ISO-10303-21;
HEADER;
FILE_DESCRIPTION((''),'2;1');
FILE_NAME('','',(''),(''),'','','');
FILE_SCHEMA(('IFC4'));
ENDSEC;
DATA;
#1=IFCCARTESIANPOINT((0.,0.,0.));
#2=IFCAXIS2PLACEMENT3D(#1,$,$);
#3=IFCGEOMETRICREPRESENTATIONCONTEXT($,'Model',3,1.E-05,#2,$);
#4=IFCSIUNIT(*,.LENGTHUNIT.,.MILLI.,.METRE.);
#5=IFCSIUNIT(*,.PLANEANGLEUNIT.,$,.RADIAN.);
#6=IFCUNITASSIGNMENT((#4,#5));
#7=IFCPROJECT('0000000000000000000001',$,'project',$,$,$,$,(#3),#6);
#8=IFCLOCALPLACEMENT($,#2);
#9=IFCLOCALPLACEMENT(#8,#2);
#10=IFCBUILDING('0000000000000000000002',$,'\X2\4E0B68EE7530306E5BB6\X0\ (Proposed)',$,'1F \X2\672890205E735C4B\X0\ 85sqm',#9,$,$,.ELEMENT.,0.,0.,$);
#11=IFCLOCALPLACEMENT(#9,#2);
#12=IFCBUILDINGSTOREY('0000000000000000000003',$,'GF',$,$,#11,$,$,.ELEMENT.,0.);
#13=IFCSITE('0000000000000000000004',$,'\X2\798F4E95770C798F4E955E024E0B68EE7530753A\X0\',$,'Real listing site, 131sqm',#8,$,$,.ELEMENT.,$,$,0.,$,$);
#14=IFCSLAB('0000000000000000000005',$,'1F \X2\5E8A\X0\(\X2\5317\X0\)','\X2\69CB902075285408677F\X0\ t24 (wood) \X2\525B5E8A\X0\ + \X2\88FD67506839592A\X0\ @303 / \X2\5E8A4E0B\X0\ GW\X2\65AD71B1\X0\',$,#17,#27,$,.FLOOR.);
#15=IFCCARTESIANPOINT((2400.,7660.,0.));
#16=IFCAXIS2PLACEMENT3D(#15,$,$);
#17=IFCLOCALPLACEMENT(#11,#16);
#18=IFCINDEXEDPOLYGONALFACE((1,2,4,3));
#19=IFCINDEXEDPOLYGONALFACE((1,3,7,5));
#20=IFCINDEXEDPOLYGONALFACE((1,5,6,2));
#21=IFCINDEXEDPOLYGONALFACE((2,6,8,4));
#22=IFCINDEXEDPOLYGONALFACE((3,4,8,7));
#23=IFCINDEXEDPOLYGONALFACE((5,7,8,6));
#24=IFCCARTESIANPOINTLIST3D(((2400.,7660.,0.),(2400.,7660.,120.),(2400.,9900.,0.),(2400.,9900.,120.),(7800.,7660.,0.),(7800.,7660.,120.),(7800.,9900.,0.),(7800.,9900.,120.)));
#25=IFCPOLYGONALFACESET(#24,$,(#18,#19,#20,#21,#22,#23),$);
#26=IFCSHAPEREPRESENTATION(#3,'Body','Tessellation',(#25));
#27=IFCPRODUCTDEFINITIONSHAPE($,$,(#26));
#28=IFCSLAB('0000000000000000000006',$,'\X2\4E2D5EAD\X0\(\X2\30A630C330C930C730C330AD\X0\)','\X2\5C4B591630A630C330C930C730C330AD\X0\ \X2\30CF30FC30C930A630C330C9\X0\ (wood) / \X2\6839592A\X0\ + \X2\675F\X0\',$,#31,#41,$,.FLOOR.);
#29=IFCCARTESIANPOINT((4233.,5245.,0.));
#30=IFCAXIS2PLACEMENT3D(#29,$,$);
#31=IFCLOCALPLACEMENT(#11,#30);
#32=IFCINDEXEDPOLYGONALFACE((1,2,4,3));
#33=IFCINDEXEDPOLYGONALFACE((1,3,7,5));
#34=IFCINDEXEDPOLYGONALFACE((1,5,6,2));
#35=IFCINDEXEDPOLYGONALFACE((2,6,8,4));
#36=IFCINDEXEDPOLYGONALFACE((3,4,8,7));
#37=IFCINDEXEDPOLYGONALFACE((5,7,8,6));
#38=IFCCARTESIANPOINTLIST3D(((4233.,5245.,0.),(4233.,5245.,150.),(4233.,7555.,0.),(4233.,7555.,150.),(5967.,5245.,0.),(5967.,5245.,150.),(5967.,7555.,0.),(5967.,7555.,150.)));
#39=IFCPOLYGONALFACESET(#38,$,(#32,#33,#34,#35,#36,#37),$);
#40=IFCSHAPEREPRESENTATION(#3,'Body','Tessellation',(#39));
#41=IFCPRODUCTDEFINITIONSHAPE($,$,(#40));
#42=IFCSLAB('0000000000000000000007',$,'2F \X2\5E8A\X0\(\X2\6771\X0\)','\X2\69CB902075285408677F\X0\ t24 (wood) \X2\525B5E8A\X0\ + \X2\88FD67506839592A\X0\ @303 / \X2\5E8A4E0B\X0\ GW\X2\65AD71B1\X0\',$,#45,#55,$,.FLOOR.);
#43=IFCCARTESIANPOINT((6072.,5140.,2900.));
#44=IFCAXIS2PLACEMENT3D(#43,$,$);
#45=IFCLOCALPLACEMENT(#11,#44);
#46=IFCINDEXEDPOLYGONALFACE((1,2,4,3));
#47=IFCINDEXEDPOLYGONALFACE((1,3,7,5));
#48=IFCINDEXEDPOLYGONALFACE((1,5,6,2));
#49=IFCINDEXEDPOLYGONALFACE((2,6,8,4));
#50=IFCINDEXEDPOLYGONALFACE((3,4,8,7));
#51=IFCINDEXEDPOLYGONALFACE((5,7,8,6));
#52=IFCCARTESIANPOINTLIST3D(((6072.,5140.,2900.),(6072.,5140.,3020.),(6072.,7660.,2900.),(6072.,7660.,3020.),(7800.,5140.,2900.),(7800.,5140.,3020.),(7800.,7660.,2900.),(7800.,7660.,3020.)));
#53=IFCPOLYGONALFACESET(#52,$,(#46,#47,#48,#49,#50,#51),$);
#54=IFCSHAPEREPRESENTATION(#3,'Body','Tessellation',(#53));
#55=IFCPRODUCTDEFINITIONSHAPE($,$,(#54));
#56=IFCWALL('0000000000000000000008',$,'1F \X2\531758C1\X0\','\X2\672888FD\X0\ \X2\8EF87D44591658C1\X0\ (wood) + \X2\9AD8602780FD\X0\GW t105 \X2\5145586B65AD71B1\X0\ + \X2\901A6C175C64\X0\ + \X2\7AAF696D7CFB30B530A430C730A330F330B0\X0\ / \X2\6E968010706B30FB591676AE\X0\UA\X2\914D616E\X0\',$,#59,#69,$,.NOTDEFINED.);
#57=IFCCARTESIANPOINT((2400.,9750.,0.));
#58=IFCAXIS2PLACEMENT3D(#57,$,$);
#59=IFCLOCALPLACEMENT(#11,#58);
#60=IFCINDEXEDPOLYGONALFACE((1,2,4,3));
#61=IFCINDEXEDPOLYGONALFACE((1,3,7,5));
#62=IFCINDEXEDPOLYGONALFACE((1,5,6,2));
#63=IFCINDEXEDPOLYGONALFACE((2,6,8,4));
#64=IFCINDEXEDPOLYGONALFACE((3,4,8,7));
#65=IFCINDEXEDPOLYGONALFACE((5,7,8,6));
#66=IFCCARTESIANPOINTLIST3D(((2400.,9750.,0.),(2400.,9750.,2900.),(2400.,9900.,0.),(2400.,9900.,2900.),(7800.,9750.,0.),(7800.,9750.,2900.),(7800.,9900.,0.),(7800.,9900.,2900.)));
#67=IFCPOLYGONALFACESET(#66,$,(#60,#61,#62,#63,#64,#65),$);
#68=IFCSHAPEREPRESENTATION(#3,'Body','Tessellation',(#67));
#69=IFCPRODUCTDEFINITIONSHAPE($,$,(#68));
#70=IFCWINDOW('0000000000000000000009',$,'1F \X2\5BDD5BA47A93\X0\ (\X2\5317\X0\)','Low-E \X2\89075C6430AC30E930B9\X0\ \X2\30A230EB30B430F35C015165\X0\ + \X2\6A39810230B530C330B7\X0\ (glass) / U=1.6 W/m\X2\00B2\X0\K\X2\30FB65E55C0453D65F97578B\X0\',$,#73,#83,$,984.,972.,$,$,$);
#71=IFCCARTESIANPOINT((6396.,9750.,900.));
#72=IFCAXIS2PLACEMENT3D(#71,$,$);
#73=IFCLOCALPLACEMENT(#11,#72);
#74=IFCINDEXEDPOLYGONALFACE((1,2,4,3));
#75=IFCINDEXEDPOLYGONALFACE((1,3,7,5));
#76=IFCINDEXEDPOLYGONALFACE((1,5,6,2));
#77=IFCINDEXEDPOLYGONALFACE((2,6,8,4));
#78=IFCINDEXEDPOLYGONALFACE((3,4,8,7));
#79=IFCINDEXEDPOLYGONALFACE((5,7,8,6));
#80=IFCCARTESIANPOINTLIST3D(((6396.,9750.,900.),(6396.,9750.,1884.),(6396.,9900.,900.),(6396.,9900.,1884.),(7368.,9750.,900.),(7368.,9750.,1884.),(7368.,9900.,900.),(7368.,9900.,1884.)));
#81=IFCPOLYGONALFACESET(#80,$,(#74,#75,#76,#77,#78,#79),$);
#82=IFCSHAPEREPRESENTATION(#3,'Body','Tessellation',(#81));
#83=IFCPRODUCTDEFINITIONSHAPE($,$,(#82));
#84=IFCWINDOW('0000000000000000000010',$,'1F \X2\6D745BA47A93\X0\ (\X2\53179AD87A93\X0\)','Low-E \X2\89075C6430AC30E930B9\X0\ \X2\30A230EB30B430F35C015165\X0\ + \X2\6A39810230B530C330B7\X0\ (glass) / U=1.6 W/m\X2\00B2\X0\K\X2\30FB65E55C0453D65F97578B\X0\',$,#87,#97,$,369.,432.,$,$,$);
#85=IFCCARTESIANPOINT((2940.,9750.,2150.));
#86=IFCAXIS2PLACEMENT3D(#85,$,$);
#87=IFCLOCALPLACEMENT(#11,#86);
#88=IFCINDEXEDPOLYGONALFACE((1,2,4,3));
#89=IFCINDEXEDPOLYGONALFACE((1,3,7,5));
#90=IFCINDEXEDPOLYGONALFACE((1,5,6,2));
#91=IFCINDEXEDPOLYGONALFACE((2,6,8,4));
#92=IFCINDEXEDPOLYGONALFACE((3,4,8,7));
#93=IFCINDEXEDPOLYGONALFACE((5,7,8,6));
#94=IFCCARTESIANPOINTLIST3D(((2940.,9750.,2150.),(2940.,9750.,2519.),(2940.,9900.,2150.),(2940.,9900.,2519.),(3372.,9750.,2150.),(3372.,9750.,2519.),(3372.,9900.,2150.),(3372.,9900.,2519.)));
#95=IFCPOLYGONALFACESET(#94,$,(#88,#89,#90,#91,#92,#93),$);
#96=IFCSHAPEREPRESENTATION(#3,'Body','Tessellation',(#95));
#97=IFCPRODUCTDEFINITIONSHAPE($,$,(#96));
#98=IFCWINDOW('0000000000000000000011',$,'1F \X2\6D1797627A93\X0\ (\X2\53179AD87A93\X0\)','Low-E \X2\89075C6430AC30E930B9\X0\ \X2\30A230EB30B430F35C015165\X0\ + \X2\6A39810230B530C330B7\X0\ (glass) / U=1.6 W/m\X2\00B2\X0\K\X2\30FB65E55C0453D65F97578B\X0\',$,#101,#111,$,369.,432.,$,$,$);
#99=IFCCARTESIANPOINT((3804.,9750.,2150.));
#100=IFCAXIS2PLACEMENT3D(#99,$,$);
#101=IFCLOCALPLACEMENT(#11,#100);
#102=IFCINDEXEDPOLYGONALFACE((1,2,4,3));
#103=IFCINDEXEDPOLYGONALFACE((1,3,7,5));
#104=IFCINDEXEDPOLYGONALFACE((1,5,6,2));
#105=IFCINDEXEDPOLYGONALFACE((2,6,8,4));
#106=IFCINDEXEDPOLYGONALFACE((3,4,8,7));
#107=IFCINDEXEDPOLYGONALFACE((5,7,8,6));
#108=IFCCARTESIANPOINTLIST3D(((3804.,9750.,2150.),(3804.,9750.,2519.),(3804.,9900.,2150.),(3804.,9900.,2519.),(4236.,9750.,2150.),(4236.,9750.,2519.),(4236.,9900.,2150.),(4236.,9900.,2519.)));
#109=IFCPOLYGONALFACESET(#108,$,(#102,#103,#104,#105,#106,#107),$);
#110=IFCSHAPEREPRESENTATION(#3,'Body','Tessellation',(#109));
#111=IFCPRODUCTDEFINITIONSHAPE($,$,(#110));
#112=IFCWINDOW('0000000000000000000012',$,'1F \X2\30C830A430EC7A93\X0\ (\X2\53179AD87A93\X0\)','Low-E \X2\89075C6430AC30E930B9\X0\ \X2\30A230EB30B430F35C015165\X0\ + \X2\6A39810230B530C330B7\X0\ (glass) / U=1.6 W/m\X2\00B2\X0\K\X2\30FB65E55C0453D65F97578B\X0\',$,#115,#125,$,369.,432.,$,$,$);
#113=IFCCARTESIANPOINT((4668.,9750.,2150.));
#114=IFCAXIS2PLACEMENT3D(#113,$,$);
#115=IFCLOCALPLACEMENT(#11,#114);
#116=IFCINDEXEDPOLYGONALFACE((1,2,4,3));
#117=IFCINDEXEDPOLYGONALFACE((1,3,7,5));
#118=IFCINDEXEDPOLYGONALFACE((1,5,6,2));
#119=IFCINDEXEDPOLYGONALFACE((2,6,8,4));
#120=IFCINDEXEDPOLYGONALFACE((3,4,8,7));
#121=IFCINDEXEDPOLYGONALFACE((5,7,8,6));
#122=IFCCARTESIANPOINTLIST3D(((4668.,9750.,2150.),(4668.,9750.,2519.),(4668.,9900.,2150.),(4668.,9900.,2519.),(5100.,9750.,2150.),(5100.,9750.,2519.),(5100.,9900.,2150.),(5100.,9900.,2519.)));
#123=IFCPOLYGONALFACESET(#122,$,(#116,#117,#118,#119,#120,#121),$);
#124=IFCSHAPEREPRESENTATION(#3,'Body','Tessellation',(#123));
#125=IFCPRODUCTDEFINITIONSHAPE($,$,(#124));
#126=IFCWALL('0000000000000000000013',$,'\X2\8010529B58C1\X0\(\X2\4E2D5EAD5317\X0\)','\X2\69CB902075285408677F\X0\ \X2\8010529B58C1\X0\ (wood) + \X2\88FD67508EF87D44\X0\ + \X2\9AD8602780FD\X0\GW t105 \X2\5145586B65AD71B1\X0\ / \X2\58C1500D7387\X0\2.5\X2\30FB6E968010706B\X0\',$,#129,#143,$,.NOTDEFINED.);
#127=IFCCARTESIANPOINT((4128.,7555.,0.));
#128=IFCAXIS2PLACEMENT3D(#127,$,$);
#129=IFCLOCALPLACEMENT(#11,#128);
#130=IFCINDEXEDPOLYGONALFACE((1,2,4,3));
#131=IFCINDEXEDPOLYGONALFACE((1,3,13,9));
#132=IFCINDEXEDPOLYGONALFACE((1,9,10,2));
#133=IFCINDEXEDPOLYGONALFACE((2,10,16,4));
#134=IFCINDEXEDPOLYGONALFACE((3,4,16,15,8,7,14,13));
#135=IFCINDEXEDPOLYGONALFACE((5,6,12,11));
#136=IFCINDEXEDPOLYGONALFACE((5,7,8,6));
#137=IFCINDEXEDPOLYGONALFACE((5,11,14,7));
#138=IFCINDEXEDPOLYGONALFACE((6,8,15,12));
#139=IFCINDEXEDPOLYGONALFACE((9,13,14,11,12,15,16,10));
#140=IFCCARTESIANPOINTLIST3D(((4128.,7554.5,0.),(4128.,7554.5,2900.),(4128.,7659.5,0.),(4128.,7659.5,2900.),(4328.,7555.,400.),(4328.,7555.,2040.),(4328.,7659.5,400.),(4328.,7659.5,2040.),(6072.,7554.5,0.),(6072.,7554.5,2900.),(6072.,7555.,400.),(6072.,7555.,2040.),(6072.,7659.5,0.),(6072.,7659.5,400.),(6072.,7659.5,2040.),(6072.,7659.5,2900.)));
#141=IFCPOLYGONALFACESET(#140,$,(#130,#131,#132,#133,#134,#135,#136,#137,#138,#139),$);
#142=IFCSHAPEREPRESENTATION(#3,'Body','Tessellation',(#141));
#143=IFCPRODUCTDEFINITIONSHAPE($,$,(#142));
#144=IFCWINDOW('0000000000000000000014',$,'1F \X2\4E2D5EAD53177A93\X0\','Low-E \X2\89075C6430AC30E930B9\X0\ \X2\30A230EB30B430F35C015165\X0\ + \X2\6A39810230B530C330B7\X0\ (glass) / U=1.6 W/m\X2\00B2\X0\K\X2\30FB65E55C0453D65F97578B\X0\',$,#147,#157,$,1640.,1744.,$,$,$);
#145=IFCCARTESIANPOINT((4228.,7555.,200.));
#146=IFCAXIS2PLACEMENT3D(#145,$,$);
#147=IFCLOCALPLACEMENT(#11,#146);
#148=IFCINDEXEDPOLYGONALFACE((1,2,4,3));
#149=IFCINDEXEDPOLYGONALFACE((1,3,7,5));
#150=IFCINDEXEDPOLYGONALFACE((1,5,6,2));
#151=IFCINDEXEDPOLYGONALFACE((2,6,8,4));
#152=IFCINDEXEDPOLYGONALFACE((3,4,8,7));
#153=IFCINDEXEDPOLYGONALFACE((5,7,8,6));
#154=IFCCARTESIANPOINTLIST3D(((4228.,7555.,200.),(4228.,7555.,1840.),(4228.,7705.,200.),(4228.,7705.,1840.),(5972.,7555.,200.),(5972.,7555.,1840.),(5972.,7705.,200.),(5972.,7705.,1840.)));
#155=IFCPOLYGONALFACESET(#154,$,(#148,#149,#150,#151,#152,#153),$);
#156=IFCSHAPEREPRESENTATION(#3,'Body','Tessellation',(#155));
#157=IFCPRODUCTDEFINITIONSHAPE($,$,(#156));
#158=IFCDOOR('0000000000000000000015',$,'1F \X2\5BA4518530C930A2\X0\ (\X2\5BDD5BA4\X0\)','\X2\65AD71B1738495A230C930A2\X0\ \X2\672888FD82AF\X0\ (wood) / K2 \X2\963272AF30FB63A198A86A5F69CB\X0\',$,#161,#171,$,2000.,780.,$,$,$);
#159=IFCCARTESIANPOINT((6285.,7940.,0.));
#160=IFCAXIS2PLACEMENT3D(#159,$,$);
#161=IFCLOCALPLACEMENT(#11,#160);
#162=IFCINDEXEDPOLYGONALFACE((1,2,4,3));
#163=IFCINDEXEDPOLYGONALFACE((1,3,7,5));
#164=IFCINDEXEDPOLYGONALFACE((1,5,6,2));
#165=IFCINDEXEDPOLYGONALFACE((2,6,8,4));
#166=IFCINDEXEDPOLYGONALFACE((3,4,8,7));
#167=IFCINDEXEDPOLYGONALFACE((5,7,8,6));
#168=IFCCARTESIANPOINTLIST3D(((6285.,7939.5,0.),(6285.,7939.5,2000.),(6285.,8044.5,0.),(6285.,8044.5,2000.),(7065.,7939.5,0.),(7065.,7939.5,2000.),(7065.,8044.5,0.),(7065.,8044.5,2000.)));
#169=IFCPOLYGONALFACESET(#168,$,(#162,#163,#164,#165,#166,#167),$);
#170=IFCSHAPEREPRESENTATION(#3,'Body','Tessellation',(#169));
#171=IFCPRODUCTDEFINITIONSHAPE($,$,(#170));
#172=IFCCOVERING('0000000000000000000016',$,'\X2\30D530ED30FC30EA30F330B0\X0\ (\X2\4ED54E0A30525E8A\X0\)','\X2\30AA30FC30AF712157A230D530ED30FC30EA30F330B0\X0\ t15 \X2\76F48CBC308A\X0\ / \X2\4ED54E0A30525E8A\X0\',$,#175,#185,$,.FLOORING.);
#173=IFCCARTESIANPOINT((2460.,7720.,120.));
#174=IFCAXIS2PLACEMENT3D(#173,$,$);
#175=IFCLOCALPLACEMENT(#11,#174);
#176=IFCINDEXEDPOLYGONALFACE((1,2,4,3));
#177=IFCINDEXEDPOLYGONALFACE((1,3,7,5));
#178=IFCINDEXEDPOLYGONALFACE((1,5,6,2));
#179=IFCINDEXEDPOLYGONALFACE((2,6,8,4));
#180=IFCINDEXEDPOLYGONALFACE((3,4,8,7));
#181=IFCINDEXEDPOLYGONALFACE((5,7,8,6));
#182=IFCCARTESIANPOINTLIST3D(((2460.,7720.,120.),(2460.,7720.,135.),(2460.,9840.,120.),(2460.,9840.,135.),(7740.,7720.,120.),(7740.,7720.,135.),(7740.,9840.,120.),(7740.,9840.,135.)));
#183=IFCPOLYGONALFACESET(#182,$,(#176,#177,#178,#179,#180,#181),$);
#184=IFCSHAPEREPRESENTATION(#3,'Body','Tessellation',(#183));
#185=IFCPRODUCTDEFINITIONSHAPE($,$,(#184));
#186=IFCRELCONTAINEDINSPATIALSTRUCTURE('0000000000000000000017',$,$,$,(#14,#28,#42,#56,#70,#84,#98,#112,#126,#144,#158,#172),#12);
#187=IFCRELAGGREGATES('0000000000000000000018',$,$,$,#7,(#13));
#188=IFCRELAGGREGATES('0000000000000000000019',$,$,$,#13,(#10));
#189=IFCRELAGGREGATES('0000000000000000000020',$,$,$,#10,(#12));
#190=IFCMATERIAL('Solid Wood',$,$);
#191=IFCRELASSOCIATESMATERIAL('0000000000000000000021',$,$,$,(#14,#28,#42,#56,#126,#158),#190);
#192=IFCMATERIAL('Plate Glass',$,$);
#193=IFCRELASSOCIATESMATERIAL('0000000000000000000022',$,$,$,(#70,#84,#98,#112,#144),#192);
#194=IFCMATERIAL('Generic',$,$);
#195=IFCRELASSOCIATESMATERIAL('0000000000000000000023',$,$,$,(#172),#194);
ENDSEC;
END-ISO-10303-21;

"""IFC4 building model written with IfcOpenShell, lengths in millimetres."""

from ifc_helpers import new_model, si_unit, frame, frame_2d, origin, place, context, project, spatial, rectangle, extrude, material, element, fill, save


model = new_model("IFC4")

# Units and contexts
model_context = context("Model", 3, precision=1e-05, world=origin())
ifc_project = project(units=[si_unit("LENGTHUNIT", "METRE", prefix="MILLI"), si_unit("PLANEANGLEUNIT", "RADIAN")], contexts=[model_context])

# Site, building, storey
site_placement = place(None, origin())
site = spatial("IfcSite", under=ifc_project, at=site_placement, Name="福井県福井市下森田町", ObjectType="Real listing site, 131sqm", CompositionType="ELEMENT", RefElevation=0.0)
building_placement = place(site_placement, origin())
building = spatial("IfcBuilding", under=site, at=building_placement, Name="下森田の家 (Proposed)", ObjectType="1F 木造平屋 85sqm", CompositionType="ELEMENT", ElevationOfRefHeight=0.0, ElevationOfTerrain=0.0)
storey_placement = place(building_placement, origin())
storey = spatial("IfcBuildingStorey", under=building, at=storey_placement, Name="GF", CompositionType="ELEMENT", Elevation=0.0)

# Slabs
ifc_material_1 = material(Name="Solid Wood")
slab_1_placement = place(storey_placement, frame((2400.0, 7660.0, 0.0)))
element("IfcSlab", 1, at=slab_1_placement, inside=storey, material=ifc_material_1, Name="1F 床(北)", Description="構造用合板 t24 (wood) 剛床 + 製材根太 @303 / 床下 GW断熱", PredefinedType="FLOOR", context=model_context, shape_type="SweptSolid", body=[
    extrude(rectangle(XDim=5400.0, YDim=2240.0, at=frame_2d((2700.0, 1120.0))), frame((2400.0, 7660.0, 0.0)), (0.0, 0.0, 1.0), 120.0),
])
slab_2_placement = place(storey_placement, frame((4233.0, 5245.0, 0.0)))
element("IfcSlab", 2, at=slab_2_placement, inside=storey, material=ifc_material_1, Name="中庭(ウッドデッキ)", Description="屋外ウッドデッキ ハードウッド (wood) / 根太 + 束", PredefinedType="FLOOR", context=model_context, shape_type="SweptSolid", body=[
    extrude(rectangle(XDim=1734.0, YDim=2310.0, at=frame_2d((867.0, 1155.0))), frame((4233.0, 5245.0, 0.0)), (0.0, 0.0, 1.0), 150.0),
])
slab_3_placement = place(storey_placement, frame((6072.0, 5140.0, 2900.0)))
element("IfcSlab", 3, at=slab_3_placement, inside=storey, material=ifc_material_1, Name="2F 床(東)", Description="構造用合板 t24 (wood) 剛床 + 製材根太 @303 / 床下 GW断熱", PredefinedType="FLOOR", context=model_context, shape_type="SweptSolid", body=[
    extrude(rectangle(XDim=1728.0, YDim=2520.0, at=frame_2d((864.0, 1260.0))), frame((6072.0, 5140.0, 2900.0)), (0.0, 0.0, 1.0), 120.0),
])

# Wall, openings, windows
wall_1_placement = place(storey_placement, frame((2400.0, 9750.0, 0.0)))
wall_1 = element("IfcWall", 4, at=wall_1_placement, inside=storey, material=ifc_material_1, Name="1F 北壁", Description="木製 軸組外壁 (wood) + 高性能GW t105 充填断熱 + 通気層 + 窯業系サイディング / 準耐火・外皮UA配慮", PredefinedType="NOTDEFINED", context=model_context, shape_type="SweptSolid", body=[
    extrude(rectangle(XDim=5400.0, YDim=150.0, at=frame_2d((2700.0, 75.0))), frame((2400.0, 9750.0, 0.0)), (0.0, 0.0, 1.0), 2900.0),
])
opening_1_placement = place(storey_placement, frame((6396.0, 9750.0, 900.0)))
opening_1 = element("IfcOpeningElement", 5, at=opening_1_placement, cuts=wall_1, PredefinedType="NOTDEFINED", context=model_context, shape_type="SweptSolid", body=[
    extrude(rectangle(XDim=972.0, YDim=150.0, at=frame_2d((486.0, 75.0))), frame((6396.0, 9750.0, 900.0)), (0.0, 0.0, 1.0), 984.0),
])
opening_2_placement = place(storey_placement, frame((2940.0, 9750.0, 2150.0)))
opening_2 = element("IfcOpeningElement", 6, at=opening_2_placement, cuts=wall_1, PredefinedType="NOTDEFINED", context=model_context, shape_type="SweptSolid", body=[
    extrude(rectangle(XDim=432.0, YDim=150.0, at=frame_2d((216.0, 75.0))), frame((2940.0, 9750.0, 2150.0)), (0.0, 0.0, 1.0), 369.0),
])
opening_3_placement = place(storey_placement, frame((3804.0, 9750.0, 2150.0)))
opening_3 = element("IfcOpeningElement", 7, at=opening_3_placement, cuts=wall_1, PredefinedType="NOTDEFINED", context=model_context, shape_type="SweptSolid", body=[
    extrude(rectangle(XDim=432.0, YDim=150.0, at=frame_2d((216.0, 75.0))), frame((3804.0, 9750.0, 2150.0)), (0.0, 0.0, 1.0), 369.0),
])
opening_4_placement = place(storey_placement, frame((4668.0, 9750.0, 2150.0)))
opening_4 = element("IfcOpeningElement", 8, at=opening_4_placement, cuts=wall_1, PredefinedType="NOTDEFINED", context=model_context, shape_type="SweptSolid", body=[
    extrude(rectangle(XDim=432.0, YDim=150.0, at=frame_2d((216.0, 75.0))), frame((4668.0, 9750.0, 2150.0)), (0.0, 0.0, 1.0), 369.0),
])
ifc_material_2 = material(Name="Plate Glass")
window_1_placement = place(storey_placement, frame((6396.0, 9750.0, 900.0)))
window_1 = element("IfcWindow", 9, at=window_1_placement, inside=storey, material=ifc_material_2, Name="1F 寝室窓 (北)", Description="Low-E 複層ガラス アルゴン封入 + 樹脂サッシ (glass) / U=1.6 W/m²K・日射取得型", OverallHeight=984.0, OverallWidth=972.0, context=model_context, shape_type="SweptSolid", body=[
    extrude(rectangle(XDim=972.0, YDim=150.0, at=frame_2d((486.0, 75.0))), frame((6396.0, 9750.0, 900.0)), (0.0, 0.0, 1.0), 984.0),
])
fill(opening_1, window_1)
window_2_placement = place(storey_placement, frame((2940.0, 9750.0, 2150.0)))
window_2 = element("IfcWindow", 10, at=window_2_placement, inside=storey, material=ifc_material_2, Name="1F 浴室窓 (北高窓)", Description="Low-E 複層ガラス アルゴン封入 + 樹脂サッシ (glass) / U=1.6 W/m²K・日射取得型", OverallHeight=369.0, OverallWidth=432.0, context=model_context, shape_type="SweptSolid", body=[
    extrude(rectangle(XDim=432.0, YDim=150.0, at=frame_2d((216.0, 75.0))), frame((2940.0, 9750.0, 2150.0)), (0.0, 0.0, 1.0), 369.0),
])
fill(opening_2, window_2)
window_3_placement = place(storey_placement, frame((3804.0, 9750.0, 2150.0)))
window_3 = element("IfcWindow", 11, at=window_3_placement, inside=storey, material=ifc_material_2, Name="1F 洗面窓 (北高窓)", Description="Low-E 複層ガラス アルゴン封入 + 樹脂サッシ (glass) / U=1.6 W/m²K・日射取得型", OverallHeight=369.0, OverallWidth=432.0, context=model_context, shape_type="SweptSolid", body=[
    extrude(rectangle(XDim=432.0, YDim=150.0, at=frame_2d((216.0, 75.0))), frame((3804.0, 9750.0, 2150.0)), (0.0, 0.0, 1.0), 369.0),
])
fill(opening_3, window_3)
window_4_placement = place(storey_placement, frame((4668.0, 9750.0, 2150.0)))
window_4 = element("IfcWindow", 12, at=window_4_placement, inside=storey, material=ifc_material_2, Name="1F トイレ窓 (北高窓)", Description="Low-E 複層ガラス アルゴン封入 + 樹脂サッシ (glass) / U=1.6 W/m²K・日射取得型", OverallHeight=369.0, OverallWidth=432.0, context=model_context, shape_type="SweptSolid", body=[
    extrude(rectangle(XDim=432.0, YDim=150.0, at=frame_2d((216.0, 75.0))), frame((4668.0, 9750.0, 2150.0)), (0.0, 0.0, 1.0), 369.0),
])
fill(opening_4, window_4)

# Wall, opening, window
wall_2_placement = place(storey_placement, frame((4128.0, 7555.0, 0.0)))
wall_2 = element("IfcWall", 13, at=wall_2_placement, inside=storey, material=ifc_material_1, Name="耐力壁(中庭北)", Description="構造用合板 耐力壁 (wood) + 製材軸組 + 高性能GW t105 充填断熱 / 壁倍率2.5・準耐火", PredefinedType="NOTDEFINED", context=model_context, shape_type="SweptSolid", body=[
    extrude(rectangle(XDim=1944.0, YDim=105.0, at=frame_2d((972.0, 52.0))), frame((4128.0, 7555.0, 0.0)), (0.0, 0.0, 1.0), 2900.0),
])
opening_5_placement = place(storey_placement, frame((4228.0, 7555.0, 200.0)))
opening_5 = element("IfcOpeningElement", 14, at=opening_5_placement, cuts=wall_2, PredefinedType="NOTDEFINED", context=model_context, shape_type="SweptSolid", body=[
    extrude(rectangle(XDim=1744.0, YDim=150.0, at=frame_2d((872.0, 75.0))), frame((4228.0, 7555.0, 200.0)), (0.0, 0.0, 1.0), 1640.0),
])
window_5_placement = place(storey_placement, frame((4228.0, 7555.0, 200.0)))
window_5 = element("IfcWindow", 15, at=window_5_placement, inside=storey, material=ifc_material_2, Name="1F 中庭北窓", Description="Low-E 複層ガラス アルゴン封入 + 樹脂サッシ (glass) / U=1.6 W/m²K・日射取得型", OverallHeight=1640.0, OverallWidth=1744.0, context=model_context, shape_type="SweptSolid", body=[
    extrude(rectangle(XDim=1744.0, YDim=150.0, at=frame_2d((872.0, 75.0))), frame((4228.0, 7555.0, 200.0)), (0.0, 0.0, 1.0), 1640.0),
])
fill(opening_5, window_5)

# Door
door_1_placement = place(storey_placement, frame((6285.0, 7940.0, 0.0)))
element("IfcDoor", 16, at=door_1_placement, inside=storey, material=ifc_material_1, Name="1F 室内ドア (寝室)", Description="断熱玄関ドア 木製芯 (wood) / K2 防犯・採風機構", OverallHeight=2000.0, OverallWidth=780.0, context=model_context, shape_type="SweptSolid", body=[
    extrude(rectangle(XDim=780.0, YDim=105.0, at=frame_2d((390.0, 52.0))), frame((6285.0, 7940.0, 0.0)), (0.0, 0.0, 1.0), 2000.0),
])

# Covering
ifc_material_3 = material(Name="Generic")
covering_1_placement = place(storey_placement, frame((2460.0, 7720.0, 120.0)))
element("IfcCovering", 17, at=covering_1_placement, inside=storey, material=ifc_material_3, Name="フローリング (仕上げ床)", Description="オーク無垢フローリング t15 直貼り / 仕上げ床", PredefinedType="FLOORING", context=model_context, shape_type="SweptSolid", body=[
    extrude(rectangle(XDim=5280.0, YDim=2120.0, at=frame_2d((2640.0, 1060.0))), frame((2460.0, 7720.0, 120.0)), (0.0, 0.0, 1.0), 15.0),
])

save(model, "model.ifc")
